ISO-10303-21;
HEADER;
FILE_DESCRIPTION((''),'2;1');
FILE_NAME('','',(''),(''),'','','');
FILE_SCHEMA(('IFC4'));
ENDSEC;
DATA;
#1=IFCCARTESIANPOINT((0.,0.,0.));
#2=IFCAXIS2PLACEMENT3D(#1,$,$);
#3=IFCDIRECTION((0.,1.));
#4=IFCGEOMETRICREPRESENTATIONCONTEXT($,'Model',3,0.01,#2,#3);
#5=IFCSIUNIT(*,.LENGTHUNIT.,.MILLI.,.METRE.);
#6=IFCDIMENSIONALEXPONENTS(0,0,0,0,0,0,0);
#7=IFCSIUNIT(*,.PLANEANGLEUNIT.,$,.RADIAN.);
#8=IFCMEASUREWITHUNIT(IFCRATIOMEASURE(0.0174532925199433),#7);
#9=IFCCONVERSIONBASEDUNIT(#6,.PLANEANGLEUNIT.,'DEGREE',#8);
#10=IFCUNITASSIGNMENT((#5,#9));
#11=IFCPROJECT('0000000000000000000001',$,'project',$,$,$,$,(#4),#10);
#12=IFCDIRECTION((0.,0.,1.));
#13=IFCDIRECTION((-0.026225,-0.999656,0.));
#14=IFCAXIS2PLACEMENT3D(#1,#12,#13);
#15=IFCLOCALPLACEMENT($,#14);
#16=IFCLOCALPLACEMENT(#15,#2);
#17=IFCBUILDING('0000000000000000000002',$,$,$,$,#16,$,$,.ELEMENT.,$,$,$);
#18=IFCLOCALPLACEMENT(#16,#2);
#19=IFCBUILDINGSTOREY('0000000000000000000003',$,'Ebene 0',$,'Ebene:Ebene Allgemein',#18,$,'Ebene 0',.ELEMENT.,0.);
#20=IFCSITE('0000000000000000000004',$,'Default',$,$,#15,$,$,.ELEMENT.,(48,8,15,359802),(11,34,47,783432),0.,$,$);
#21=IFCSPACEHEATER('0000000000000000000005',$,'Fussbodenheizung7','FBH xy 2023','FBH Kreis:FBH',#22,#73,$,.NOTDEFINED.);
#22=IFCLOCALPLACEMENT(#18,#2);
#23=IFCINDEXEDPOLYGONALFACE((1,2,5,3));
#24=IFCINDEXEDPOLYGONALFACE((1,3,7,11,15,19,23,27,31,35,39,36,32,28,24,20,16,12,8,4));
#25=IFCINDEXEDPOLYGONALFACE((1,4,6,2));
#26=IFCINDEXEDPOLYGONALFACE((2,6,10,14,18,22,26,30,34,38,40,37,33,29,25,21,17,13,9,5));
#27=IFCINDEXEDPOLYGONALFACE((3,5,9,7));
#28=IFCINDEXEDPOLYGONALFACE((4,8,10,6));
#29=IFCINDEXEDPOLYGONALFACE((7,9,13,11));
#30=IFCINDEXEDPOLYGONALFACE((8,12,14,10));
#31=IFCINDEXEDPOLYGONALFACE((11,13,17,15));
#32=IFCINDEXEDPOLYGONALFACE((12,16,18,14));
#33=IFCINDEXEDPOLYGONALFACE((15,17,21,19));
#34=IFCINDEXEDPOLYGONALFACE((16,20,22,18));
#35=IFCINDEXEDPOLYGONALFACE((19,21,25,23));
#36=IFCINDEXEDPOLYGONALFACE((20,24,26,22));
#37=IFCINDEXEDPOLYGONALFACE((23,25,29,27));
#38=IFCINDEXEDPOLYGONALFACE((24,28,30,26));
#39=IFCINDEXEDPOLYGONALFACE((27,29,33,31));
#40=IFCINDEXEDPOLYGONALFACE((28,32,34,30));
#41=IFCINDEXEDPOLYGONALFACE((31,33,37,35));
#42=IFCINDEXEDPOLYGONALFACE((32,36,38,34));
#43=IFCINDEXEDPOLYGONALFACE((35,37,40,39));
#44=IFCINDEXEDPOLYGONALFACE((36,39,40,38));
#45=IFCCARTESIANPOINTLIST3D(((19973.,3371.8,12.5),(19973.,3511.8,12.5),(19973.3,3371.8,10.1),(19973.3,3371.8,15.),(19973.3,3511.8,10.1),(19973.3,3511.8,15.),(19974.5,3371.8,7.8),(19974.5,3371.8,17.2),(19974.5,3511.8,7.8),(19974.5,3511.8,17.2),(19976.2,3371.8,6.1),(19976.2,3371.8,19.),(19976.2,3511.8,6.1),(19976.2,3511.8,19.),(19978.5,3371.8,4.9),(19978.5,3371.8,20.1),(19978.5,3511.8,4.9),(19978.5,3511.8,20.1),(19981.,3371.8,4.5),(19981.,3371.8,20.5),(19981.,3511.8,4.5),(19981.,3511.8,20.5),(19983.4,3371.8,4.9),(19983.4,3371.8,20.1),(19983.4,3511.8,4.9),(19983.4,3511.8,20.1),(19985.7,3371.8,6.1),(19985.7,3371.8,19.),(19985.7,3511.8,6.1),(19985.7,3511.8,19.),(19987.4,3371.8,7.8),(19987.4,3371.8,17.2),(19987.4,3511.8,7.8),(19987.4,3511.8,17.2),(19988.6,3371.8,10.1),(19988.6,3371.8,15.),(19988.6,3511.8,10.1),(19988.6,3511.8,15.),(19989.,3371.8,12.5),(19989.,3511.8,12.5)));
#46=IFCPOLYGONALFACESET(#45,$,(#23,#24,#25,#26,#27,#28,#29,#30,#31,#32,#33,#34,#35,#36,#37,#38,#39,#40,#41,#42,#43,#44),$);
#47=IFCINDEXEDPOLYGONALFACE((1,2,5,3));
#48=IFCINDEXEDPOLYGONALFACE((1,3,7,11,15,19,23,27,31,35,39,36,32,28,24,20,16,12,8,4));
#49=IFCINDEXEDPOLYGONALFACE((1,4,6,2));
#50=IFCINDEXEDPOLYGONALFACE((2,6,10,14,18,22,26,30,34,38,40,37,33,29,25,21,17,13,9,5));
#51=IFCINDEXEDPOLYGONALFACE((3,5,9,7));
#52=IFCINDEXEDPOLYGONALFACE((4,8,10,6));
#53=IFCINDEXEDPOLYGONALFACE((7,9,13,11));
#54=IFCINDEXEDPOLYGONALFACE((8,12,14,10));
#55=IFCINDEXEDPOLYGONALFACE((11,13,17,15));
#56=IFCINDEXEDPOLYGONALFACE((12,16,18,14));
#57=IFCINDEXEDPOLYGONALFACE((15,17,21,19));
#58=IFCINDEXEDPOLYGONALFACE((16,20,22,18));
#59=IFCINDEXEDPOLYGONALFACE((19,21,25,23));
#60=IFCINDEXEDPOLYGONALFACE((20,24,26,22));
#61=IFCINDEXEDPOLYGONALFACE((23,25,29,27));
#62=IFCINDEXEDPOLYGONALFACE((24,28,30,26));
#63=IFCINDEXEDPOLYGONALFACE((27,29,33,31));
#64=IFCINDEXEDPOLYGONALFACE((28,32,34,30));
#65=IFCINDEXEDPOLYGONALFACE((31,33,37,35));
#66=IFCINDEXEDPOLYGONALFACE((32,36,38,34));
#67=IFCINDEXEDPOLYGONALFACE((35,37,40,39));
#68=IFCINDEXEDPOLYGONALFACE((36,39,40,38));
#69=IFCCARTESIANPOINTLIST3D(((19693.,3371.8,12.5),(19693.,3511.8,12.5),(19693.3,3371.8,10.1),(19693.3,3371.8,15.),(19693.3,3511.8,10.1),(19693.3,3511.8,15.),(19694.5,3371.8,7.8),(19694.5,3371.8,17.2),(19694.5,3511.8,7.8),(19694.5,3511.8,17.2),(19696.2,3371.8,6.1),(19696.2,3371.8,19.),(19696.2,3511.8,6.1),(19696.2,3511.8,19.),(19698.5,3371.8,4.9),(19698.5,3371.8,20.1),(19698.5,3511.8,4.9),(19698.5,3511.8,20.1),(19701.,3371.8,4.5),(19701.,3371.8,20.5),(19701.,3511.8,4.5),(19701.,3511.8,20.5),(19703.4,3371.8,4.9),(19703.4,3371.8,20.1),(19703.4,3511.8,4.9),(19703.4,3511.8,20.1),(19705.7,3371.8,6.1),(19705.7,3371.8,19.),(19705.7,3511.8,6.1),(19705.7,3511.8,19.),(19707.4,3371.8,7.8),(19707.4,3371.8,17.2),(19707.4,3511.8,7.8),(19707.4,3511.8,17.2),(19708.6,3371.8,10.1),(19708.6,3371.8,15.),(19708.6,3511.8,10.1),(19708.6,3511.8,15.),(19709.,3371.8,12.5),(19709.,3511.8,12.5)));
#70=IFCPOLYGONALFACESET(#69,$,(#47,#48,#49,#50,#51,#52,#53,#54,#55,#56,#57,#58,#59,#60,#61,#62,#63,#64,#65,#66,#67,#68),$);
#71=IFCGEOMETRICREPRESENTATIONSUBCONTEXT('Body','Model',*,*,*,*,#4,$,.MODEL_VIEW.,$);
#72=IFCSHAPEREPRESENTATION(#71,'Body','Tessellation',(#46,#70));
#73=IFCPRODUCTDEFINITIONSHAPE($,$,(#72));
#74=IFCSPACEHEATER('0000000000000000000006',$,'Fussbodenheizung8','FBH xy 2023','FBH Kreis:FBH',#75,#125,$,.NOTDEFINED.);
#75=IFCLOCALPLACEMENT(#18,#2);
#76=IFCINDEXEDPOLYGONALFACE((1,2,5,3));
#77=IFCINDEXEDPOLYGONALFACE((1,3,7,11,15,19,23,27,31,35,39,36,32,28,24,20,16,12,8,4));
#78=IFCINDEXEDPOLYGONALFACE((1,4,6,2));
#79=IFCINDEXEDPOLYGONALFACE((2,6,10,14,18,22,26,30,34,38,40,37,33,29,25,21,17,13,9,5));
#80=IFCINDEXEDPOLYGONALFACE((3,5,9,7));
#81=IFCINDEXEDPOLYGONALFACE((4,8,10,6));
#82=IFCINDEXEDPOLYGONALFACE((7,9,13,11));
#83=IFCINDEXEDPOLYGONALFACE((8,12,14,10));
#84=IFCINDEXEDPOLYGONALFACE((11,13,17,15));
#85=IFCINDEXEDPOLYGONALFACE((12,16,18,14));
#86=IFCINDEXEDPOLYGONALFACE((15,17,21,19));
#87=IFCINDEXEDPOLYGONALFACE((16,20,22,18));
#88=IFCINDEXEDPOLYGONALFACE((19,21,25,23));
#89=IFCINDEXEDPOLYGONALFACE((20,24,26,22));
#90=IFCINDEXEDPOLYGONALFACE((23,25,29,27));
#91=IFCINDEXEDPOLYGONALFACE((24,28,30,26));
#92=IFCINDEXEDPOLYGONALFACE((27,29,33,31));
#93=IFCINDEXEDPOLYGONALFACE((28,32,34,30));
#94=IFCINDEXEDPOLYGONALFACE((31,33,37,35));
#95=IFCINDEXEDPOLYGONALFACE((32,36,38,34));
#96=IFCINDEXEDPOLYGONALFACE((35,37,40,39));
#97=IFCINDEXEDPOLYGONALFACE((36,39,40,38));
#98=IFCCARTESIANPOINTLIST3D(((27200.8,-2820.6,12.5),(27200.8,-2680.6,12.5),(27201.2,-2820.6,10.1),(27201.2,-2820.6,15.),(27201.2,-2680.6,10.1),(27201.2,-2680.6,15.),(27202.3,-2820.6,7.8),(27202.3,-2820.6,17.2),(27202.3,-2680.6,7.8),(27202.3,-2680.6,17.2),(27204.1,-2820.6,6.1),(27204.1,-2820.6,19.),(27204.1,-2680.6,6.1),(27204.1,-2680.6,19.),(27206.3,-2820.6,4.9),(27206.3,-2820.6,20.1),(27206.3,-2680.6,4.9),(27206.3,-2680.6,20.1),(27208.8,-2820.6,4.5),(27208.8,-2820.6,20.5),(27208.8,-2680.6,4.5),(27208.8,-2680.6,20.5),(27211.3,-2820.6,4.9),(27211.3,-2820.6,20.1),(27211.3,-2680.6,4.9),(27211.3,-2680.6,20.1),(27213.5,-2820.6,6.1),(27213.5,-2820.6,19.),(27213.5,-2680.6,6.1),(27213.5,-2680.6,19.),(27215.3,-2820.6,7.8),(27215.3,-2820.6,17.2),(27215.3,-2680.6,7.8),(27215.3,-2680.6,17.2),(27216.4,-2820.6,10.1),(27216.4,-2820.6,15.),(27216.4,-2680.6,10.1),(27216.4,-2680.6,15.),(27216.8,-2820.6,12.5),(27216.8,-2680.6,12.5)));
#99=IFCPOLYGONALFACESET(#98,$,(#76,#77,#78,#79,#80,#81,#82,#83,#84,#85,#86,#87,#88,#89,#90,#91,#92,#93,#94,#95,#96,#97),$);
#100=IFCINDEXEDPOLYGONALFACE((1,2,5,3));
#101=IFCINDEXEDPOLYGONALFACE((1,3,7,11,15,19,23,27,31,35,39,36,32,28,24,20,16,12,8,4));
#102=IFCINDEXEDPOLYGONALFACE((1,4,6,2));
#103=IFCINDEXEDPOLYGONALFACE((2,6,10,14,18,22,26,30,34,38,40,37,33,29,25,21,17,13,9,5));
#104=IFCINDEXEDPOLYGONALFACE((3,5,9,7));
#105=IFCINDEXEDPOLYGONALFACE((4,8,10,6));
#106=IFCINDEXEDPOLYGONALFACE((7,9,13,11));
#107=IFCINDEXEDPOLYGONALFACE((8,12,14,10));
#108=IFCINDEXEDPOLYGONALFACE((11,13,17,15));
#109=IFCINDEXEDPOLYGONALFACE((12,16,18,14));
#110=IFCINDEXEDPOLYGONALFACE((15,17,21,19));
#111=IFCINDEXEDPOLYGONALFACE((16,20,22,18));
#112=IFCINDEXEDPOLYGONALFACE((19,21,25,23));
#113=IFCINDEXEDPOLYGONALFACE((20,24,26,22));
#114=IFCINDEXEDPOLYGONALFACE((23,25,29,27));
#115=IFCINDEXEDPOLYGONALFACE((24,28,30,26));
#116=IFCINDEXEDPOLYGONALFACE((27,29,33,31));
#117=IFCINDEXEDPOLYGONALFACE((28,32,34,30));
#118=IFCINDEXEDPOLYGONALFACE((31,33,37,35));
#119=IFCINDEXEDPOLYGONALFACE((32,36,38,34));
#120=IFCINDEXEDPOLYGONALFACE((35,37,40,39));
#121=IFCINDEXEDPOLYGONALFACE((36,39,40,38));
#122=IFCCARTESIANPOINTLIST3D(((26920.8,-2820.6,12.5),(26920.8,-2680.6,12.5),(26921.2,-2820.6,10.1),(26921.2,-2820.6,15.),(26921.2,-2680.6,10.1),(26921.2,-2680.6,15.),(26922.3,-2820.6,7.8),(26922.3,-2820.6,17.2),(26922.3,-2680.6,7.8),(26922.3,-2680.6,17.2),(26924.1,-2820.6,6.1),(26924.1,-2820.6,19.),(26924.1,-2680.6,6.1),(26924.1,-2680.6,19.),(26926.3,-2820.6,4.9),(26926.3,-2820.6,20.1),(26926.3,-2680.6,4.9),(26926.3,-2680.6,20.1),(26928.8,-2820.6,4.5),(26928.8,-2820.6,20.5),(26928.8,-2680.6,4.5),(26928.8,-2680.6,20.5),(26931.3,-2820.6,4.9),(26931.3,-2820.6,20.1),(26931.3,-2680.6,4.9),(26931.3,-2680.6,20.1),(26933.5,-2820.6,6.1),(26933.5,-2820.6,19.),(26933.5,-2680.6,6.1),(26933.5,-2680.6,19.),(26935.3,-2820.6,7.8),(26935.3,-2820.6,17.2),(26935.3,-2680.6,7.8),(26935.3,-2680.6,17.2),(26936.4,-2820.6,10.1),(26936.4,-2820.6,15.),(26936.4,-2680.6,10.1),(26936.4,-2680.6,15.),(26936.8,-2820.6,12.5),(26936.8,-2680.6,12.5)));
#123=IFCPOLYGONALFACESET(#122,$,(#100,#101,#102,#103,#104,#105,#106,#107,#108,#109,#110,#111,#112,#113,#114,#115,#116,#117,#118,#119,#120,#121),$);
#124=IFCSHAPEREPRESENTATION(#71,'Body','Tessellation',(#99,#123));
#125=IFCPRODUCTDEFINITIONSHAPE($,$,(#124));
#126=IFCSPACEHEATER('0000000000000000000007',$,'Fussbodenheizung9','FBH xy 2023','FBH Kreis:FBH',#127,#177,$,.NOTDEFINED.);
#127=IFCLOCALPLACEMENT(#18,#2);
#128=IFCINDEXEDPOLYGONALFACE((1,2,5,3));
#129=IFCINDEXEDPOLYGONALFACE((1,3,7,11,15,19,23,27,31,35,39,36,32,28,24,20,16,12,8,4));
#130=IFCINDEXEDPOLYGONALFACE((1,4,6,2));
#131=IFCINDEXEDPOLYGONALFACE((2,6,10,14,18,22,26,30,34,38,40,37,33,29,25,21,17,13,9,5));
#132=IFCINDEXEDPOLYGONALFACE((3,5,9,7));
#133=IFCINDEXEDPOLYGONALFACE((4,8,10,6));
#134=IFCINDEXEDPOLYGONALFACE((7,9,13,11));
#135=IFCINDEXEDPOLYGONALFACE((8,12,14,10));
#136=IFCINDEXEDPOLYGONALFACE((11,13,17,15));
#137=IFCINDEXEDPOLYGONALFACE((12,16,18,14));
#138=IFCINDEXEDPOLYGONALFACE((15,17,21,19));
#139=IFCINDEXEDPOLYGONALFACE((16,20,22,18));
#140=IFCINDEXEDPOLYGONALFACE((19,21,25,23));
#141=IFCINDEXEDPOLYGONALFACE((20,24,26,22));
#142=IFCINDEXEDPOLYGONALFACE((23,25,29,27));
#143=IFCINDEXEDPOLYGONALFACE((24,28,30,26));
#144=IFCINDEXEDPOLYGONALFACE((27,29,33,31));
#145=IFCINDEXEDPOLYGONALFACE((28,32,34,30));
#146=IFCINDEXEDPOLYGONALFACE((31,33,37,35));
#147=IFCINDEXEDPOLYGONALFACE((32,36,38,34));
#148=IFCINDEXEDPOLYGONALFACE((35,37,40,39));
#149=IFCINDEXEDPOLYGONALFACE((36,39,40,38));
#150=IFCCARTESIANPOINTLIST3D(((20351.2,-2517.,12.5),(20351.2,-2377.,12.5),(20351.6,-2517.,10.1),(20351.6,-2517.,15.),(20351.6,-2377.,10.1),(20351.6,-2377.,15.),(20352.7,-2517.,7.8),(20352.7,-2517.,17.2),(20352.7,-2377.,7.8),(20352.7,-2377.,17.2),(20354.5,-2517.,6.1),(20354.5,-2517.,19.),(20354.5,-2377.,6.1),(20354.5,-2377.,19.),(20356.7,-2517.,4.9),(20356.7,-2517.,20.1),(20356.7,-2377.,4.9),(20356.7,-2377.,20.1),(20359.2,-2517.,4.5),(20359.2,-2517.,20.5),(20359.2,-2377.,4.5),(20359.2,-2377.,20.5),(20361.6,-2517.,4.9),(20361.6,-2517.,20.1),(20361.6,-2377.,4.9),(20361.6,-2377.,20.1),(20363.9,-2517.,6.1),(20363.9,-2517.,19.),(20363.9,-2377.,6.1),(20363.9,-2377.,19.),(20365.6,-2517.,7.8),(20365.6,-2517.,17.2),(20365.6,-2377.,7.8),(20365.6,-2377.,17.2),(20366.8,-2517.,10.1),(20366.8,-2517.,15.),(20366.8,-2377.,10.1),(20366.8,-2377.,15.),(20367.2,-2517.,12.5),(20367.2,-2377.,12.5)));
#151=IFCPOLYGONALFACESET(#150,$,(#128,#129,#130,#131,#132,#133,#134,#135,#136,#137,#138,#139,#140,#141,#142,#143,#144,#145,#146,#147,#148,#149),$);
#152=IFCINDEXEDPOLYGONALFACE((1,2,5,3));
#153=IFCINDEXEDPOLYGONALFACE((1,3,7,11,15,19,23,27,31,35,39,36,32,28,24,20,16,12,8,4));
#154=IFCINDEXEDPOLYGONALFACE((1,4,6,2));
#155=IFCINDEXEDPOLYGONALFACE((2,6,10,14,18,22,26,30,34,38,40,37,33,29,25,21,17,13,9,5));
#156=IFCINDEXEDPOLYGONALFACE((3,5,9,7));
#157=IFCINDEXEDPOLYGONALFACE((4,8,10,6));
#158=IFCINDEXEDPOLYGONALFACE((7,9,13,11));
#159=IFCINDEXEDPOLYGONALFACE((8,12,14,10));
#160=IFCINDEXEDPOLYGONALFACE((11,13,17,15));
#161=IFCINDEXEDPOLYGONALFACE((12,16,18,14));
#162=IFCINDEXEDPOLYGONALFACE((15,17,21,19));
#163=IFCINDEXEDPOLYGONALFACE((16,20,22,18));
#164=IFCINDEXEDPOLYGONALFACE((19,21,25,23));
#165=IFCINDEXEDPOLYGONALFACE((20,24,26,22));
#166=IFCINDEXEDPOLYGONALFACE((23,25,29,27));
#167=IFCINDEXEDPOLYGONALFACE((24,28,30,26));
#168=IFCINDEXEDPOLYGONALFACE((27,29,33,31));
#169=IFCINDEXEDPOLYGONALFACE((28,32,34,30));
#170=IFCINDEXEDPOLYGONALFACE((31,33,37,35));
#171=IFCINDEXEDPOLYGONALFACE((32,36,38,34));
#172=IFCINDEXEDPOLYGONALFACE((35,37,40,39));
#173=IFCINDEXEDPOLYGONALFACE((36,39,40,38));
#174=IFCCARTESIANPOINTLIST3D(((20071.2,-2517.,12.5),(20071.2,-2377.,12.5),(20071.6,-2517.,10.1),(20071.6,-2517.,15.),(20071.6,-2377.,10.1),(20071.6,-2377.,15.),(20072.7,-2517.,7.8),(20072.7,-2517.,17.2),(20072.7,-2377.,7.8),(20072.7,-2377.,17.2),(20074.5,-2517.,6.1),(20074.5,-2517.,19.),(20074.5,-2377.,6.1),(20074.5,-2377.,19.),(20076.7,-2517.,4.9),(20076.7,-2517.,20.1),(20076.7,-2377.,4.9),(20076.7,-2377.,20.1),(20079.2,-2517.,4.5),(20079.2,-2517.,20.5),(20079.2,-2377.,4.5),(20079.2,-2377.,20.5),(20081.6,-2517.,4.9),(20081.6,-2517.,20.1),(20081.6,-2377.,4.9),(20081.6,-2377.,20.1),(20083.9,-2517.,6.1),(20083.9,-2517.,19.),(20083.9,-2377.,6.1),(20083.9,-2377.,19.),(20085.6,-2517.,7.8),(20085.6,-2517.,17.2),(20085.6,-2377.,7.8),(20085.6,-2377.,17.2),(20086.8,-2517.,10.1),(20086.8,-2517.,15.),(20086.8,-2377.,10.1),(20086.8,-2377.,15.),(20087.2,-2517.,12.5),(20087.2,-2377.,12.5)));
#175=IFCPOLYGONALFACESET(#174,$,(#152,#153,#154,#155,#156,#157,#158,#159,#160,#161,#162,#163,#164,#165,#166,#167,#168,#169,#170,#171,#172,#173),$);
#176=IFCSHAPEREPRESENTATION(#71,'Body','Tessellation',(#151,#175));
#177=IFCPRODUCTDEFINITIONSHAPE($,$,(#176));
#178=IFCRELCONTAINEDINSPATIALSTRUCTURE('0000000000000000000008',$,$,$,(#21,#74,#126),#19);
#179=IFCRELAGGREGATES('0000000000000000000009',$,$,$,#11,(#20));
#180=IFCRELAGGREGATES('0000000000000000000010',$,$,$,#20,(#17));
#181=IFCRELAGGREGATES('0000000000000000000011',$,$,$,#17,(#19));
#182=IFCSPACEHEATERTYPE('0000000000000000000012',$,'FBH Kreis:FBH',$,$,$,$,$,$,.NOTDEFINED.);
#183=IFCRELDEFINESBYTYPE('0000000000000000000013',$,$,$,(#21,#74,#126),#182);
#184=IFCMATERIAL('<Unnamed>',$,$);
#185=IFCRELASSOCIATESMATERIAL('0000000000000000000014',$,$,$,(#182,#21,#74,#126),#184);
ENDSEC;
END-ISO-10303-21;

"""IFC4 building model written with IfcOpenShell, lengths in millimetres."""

from ifc_helpers import new_model, entity, si_unit, converted_unit, direction, frame, origin, place, context, subcontext, project, spatial, indexed_curve, outline, extrude, source, transform, mapped, material, type_object, type_shapes, element, save


model = new_model("IFC4")

# Units and contexts
model_context = context("Model", 3, precision=0.01, world=origin(), true_north=direction((0.0, 1.0)))
body_context = subcontext(model_context, "Body", "Model", "MODEL_VIEW")
ifc_project = project(units=[si_unit("LENGTHUNIT", "METRE", prefix="MILLI"), converted_unit("PLANEANGLEUNIT", "DEGREE", entity("IfcRatioMeasure", 0.0174532925199433), si_unit("PLANEANGLEUNIT", "RADIAN"), dimensions=[0, 0, 0, 0, 0, 0, 0])], contexts=[model_context])

# Site, building, storey
site_placement = place(None, frame((0.0, 0.0, 0.0), z_axis=(0.0, 0.0, 1.0), x_axis=(-0.026225, -0.999656, 0.0)))
site = spatial("IfcSite", under=ifc_project, at=site_placement, Name="Default", CompositionType="ELEMENT", RefLatitude=(48, 8, 15, 359802), RefLongitude=(11, 34, 47, 783432), RefElevation=0.0)
building_placement = place(site_placement, origin())
building = spatial("IfcBuilding", under=site, at=building_placement, CompositionType="ELEMENT")
storey_placement = place(building_placement, origin())
storey = spatial("IfcBuildingStorey", under=building, at=storey_placement, Name="Ebene 0", ObjectType="Ebene:Ebene Allgemein", LongName="Ebene 0", CompositionType="ELEMENT", Elevation=0.0)

# Space heaters
ifc_material = material(Name="<Unnamed>")
space_heater_type = type_object("IfcSpaceHeaterType", Name="FBH Kreis:FBH", PredefinedType="NOTDEFINED", material=ifc_material)
shared_shape = source(origin(), body_context, "Body", "SweptSolid", [
    extrude(outline(indexed_curve([(8.0, 0.0), (7.6, 2.5), (6.5, 4.7), (4.7, 6.5), (2.5, 7.6), (0.0, 8.0), (-2.5, 7.6), (-4.7, 6.5), (-6.5, 4.7), (-7.6, 2.5), (-8.0, 0.0), (-7.6, -2.5), (-6.5, -4.7), (-4.7, -6.5), (-2.5, -7.6), (0.0, -8.0), (2.5, -7.6), (4.7, -6.5), (6.5, -4.7), (7.6, -2.5), (8.0, 0.0)], self_intersect=False)), frame((140.0, -1621.8, -83.0), z_axis=(0.0, 1.0, 0.0), x_axis=(1.0, 0.0, 0.0)), (0.0, 0.0, 1.0), 140.0),
    extrude(outline(indexed_curve([(8.0, 0.0), (7.6, 2.5), (6.5, 4.7), (4.7, 6.5), (2.5, 7.6), (0.0, 8.0), (-2.5, 7.6), (-4.7, 6.5), (-6.5, 4.7), (-7.6, 2.5), (-8.0, 0.0), (-7.6, -2.5), (-6.5, -4.7), (-4.7, -6.5), (-2.5, -7.6), (0.0, -8.0), (2.5, -7.6), (4.7, -6.5), (6.5, -4.7), (7.6, -2.5), (8.0, 0.0)], self_intersect=False)), frame((-140.0, -1621.8, -83.0), z_axis=(0.0, 1.0, 0.0), x_axis=(1.0, 0.0, 0.0)), (0.0, 0.0, 1.0), 140.0),
])
type_shapes(space_heater_type, [shared_shape])
for number, where, name in (
    (1, (19841.0, 4993.5, 95.5), "Fussbodenheizung7"),
    (2, (27068.8, -1198.9, 95.5), "Fussbodenheizung8"),
    (3, (20219.2, -895.2, 95.5), "Fussbodenheizung9"),
):
    element("IfcSpaceHeater", number, at=place(storey_placement, frame(where)), inside=storey, type_object=space_heater_type, material=ifc_material, Name=name, Description="FBH xy 2023", ObjectType="FBH Kreis:FBH", PredefinedType="NOTDEFINED", context=body_context, shape_type="MappedRepresentation", body=[
        mapped(shared_shape, transform((0.0, 0.0, 0.0), scale=1.0)),
    ])

save(model, "model.ifc")
